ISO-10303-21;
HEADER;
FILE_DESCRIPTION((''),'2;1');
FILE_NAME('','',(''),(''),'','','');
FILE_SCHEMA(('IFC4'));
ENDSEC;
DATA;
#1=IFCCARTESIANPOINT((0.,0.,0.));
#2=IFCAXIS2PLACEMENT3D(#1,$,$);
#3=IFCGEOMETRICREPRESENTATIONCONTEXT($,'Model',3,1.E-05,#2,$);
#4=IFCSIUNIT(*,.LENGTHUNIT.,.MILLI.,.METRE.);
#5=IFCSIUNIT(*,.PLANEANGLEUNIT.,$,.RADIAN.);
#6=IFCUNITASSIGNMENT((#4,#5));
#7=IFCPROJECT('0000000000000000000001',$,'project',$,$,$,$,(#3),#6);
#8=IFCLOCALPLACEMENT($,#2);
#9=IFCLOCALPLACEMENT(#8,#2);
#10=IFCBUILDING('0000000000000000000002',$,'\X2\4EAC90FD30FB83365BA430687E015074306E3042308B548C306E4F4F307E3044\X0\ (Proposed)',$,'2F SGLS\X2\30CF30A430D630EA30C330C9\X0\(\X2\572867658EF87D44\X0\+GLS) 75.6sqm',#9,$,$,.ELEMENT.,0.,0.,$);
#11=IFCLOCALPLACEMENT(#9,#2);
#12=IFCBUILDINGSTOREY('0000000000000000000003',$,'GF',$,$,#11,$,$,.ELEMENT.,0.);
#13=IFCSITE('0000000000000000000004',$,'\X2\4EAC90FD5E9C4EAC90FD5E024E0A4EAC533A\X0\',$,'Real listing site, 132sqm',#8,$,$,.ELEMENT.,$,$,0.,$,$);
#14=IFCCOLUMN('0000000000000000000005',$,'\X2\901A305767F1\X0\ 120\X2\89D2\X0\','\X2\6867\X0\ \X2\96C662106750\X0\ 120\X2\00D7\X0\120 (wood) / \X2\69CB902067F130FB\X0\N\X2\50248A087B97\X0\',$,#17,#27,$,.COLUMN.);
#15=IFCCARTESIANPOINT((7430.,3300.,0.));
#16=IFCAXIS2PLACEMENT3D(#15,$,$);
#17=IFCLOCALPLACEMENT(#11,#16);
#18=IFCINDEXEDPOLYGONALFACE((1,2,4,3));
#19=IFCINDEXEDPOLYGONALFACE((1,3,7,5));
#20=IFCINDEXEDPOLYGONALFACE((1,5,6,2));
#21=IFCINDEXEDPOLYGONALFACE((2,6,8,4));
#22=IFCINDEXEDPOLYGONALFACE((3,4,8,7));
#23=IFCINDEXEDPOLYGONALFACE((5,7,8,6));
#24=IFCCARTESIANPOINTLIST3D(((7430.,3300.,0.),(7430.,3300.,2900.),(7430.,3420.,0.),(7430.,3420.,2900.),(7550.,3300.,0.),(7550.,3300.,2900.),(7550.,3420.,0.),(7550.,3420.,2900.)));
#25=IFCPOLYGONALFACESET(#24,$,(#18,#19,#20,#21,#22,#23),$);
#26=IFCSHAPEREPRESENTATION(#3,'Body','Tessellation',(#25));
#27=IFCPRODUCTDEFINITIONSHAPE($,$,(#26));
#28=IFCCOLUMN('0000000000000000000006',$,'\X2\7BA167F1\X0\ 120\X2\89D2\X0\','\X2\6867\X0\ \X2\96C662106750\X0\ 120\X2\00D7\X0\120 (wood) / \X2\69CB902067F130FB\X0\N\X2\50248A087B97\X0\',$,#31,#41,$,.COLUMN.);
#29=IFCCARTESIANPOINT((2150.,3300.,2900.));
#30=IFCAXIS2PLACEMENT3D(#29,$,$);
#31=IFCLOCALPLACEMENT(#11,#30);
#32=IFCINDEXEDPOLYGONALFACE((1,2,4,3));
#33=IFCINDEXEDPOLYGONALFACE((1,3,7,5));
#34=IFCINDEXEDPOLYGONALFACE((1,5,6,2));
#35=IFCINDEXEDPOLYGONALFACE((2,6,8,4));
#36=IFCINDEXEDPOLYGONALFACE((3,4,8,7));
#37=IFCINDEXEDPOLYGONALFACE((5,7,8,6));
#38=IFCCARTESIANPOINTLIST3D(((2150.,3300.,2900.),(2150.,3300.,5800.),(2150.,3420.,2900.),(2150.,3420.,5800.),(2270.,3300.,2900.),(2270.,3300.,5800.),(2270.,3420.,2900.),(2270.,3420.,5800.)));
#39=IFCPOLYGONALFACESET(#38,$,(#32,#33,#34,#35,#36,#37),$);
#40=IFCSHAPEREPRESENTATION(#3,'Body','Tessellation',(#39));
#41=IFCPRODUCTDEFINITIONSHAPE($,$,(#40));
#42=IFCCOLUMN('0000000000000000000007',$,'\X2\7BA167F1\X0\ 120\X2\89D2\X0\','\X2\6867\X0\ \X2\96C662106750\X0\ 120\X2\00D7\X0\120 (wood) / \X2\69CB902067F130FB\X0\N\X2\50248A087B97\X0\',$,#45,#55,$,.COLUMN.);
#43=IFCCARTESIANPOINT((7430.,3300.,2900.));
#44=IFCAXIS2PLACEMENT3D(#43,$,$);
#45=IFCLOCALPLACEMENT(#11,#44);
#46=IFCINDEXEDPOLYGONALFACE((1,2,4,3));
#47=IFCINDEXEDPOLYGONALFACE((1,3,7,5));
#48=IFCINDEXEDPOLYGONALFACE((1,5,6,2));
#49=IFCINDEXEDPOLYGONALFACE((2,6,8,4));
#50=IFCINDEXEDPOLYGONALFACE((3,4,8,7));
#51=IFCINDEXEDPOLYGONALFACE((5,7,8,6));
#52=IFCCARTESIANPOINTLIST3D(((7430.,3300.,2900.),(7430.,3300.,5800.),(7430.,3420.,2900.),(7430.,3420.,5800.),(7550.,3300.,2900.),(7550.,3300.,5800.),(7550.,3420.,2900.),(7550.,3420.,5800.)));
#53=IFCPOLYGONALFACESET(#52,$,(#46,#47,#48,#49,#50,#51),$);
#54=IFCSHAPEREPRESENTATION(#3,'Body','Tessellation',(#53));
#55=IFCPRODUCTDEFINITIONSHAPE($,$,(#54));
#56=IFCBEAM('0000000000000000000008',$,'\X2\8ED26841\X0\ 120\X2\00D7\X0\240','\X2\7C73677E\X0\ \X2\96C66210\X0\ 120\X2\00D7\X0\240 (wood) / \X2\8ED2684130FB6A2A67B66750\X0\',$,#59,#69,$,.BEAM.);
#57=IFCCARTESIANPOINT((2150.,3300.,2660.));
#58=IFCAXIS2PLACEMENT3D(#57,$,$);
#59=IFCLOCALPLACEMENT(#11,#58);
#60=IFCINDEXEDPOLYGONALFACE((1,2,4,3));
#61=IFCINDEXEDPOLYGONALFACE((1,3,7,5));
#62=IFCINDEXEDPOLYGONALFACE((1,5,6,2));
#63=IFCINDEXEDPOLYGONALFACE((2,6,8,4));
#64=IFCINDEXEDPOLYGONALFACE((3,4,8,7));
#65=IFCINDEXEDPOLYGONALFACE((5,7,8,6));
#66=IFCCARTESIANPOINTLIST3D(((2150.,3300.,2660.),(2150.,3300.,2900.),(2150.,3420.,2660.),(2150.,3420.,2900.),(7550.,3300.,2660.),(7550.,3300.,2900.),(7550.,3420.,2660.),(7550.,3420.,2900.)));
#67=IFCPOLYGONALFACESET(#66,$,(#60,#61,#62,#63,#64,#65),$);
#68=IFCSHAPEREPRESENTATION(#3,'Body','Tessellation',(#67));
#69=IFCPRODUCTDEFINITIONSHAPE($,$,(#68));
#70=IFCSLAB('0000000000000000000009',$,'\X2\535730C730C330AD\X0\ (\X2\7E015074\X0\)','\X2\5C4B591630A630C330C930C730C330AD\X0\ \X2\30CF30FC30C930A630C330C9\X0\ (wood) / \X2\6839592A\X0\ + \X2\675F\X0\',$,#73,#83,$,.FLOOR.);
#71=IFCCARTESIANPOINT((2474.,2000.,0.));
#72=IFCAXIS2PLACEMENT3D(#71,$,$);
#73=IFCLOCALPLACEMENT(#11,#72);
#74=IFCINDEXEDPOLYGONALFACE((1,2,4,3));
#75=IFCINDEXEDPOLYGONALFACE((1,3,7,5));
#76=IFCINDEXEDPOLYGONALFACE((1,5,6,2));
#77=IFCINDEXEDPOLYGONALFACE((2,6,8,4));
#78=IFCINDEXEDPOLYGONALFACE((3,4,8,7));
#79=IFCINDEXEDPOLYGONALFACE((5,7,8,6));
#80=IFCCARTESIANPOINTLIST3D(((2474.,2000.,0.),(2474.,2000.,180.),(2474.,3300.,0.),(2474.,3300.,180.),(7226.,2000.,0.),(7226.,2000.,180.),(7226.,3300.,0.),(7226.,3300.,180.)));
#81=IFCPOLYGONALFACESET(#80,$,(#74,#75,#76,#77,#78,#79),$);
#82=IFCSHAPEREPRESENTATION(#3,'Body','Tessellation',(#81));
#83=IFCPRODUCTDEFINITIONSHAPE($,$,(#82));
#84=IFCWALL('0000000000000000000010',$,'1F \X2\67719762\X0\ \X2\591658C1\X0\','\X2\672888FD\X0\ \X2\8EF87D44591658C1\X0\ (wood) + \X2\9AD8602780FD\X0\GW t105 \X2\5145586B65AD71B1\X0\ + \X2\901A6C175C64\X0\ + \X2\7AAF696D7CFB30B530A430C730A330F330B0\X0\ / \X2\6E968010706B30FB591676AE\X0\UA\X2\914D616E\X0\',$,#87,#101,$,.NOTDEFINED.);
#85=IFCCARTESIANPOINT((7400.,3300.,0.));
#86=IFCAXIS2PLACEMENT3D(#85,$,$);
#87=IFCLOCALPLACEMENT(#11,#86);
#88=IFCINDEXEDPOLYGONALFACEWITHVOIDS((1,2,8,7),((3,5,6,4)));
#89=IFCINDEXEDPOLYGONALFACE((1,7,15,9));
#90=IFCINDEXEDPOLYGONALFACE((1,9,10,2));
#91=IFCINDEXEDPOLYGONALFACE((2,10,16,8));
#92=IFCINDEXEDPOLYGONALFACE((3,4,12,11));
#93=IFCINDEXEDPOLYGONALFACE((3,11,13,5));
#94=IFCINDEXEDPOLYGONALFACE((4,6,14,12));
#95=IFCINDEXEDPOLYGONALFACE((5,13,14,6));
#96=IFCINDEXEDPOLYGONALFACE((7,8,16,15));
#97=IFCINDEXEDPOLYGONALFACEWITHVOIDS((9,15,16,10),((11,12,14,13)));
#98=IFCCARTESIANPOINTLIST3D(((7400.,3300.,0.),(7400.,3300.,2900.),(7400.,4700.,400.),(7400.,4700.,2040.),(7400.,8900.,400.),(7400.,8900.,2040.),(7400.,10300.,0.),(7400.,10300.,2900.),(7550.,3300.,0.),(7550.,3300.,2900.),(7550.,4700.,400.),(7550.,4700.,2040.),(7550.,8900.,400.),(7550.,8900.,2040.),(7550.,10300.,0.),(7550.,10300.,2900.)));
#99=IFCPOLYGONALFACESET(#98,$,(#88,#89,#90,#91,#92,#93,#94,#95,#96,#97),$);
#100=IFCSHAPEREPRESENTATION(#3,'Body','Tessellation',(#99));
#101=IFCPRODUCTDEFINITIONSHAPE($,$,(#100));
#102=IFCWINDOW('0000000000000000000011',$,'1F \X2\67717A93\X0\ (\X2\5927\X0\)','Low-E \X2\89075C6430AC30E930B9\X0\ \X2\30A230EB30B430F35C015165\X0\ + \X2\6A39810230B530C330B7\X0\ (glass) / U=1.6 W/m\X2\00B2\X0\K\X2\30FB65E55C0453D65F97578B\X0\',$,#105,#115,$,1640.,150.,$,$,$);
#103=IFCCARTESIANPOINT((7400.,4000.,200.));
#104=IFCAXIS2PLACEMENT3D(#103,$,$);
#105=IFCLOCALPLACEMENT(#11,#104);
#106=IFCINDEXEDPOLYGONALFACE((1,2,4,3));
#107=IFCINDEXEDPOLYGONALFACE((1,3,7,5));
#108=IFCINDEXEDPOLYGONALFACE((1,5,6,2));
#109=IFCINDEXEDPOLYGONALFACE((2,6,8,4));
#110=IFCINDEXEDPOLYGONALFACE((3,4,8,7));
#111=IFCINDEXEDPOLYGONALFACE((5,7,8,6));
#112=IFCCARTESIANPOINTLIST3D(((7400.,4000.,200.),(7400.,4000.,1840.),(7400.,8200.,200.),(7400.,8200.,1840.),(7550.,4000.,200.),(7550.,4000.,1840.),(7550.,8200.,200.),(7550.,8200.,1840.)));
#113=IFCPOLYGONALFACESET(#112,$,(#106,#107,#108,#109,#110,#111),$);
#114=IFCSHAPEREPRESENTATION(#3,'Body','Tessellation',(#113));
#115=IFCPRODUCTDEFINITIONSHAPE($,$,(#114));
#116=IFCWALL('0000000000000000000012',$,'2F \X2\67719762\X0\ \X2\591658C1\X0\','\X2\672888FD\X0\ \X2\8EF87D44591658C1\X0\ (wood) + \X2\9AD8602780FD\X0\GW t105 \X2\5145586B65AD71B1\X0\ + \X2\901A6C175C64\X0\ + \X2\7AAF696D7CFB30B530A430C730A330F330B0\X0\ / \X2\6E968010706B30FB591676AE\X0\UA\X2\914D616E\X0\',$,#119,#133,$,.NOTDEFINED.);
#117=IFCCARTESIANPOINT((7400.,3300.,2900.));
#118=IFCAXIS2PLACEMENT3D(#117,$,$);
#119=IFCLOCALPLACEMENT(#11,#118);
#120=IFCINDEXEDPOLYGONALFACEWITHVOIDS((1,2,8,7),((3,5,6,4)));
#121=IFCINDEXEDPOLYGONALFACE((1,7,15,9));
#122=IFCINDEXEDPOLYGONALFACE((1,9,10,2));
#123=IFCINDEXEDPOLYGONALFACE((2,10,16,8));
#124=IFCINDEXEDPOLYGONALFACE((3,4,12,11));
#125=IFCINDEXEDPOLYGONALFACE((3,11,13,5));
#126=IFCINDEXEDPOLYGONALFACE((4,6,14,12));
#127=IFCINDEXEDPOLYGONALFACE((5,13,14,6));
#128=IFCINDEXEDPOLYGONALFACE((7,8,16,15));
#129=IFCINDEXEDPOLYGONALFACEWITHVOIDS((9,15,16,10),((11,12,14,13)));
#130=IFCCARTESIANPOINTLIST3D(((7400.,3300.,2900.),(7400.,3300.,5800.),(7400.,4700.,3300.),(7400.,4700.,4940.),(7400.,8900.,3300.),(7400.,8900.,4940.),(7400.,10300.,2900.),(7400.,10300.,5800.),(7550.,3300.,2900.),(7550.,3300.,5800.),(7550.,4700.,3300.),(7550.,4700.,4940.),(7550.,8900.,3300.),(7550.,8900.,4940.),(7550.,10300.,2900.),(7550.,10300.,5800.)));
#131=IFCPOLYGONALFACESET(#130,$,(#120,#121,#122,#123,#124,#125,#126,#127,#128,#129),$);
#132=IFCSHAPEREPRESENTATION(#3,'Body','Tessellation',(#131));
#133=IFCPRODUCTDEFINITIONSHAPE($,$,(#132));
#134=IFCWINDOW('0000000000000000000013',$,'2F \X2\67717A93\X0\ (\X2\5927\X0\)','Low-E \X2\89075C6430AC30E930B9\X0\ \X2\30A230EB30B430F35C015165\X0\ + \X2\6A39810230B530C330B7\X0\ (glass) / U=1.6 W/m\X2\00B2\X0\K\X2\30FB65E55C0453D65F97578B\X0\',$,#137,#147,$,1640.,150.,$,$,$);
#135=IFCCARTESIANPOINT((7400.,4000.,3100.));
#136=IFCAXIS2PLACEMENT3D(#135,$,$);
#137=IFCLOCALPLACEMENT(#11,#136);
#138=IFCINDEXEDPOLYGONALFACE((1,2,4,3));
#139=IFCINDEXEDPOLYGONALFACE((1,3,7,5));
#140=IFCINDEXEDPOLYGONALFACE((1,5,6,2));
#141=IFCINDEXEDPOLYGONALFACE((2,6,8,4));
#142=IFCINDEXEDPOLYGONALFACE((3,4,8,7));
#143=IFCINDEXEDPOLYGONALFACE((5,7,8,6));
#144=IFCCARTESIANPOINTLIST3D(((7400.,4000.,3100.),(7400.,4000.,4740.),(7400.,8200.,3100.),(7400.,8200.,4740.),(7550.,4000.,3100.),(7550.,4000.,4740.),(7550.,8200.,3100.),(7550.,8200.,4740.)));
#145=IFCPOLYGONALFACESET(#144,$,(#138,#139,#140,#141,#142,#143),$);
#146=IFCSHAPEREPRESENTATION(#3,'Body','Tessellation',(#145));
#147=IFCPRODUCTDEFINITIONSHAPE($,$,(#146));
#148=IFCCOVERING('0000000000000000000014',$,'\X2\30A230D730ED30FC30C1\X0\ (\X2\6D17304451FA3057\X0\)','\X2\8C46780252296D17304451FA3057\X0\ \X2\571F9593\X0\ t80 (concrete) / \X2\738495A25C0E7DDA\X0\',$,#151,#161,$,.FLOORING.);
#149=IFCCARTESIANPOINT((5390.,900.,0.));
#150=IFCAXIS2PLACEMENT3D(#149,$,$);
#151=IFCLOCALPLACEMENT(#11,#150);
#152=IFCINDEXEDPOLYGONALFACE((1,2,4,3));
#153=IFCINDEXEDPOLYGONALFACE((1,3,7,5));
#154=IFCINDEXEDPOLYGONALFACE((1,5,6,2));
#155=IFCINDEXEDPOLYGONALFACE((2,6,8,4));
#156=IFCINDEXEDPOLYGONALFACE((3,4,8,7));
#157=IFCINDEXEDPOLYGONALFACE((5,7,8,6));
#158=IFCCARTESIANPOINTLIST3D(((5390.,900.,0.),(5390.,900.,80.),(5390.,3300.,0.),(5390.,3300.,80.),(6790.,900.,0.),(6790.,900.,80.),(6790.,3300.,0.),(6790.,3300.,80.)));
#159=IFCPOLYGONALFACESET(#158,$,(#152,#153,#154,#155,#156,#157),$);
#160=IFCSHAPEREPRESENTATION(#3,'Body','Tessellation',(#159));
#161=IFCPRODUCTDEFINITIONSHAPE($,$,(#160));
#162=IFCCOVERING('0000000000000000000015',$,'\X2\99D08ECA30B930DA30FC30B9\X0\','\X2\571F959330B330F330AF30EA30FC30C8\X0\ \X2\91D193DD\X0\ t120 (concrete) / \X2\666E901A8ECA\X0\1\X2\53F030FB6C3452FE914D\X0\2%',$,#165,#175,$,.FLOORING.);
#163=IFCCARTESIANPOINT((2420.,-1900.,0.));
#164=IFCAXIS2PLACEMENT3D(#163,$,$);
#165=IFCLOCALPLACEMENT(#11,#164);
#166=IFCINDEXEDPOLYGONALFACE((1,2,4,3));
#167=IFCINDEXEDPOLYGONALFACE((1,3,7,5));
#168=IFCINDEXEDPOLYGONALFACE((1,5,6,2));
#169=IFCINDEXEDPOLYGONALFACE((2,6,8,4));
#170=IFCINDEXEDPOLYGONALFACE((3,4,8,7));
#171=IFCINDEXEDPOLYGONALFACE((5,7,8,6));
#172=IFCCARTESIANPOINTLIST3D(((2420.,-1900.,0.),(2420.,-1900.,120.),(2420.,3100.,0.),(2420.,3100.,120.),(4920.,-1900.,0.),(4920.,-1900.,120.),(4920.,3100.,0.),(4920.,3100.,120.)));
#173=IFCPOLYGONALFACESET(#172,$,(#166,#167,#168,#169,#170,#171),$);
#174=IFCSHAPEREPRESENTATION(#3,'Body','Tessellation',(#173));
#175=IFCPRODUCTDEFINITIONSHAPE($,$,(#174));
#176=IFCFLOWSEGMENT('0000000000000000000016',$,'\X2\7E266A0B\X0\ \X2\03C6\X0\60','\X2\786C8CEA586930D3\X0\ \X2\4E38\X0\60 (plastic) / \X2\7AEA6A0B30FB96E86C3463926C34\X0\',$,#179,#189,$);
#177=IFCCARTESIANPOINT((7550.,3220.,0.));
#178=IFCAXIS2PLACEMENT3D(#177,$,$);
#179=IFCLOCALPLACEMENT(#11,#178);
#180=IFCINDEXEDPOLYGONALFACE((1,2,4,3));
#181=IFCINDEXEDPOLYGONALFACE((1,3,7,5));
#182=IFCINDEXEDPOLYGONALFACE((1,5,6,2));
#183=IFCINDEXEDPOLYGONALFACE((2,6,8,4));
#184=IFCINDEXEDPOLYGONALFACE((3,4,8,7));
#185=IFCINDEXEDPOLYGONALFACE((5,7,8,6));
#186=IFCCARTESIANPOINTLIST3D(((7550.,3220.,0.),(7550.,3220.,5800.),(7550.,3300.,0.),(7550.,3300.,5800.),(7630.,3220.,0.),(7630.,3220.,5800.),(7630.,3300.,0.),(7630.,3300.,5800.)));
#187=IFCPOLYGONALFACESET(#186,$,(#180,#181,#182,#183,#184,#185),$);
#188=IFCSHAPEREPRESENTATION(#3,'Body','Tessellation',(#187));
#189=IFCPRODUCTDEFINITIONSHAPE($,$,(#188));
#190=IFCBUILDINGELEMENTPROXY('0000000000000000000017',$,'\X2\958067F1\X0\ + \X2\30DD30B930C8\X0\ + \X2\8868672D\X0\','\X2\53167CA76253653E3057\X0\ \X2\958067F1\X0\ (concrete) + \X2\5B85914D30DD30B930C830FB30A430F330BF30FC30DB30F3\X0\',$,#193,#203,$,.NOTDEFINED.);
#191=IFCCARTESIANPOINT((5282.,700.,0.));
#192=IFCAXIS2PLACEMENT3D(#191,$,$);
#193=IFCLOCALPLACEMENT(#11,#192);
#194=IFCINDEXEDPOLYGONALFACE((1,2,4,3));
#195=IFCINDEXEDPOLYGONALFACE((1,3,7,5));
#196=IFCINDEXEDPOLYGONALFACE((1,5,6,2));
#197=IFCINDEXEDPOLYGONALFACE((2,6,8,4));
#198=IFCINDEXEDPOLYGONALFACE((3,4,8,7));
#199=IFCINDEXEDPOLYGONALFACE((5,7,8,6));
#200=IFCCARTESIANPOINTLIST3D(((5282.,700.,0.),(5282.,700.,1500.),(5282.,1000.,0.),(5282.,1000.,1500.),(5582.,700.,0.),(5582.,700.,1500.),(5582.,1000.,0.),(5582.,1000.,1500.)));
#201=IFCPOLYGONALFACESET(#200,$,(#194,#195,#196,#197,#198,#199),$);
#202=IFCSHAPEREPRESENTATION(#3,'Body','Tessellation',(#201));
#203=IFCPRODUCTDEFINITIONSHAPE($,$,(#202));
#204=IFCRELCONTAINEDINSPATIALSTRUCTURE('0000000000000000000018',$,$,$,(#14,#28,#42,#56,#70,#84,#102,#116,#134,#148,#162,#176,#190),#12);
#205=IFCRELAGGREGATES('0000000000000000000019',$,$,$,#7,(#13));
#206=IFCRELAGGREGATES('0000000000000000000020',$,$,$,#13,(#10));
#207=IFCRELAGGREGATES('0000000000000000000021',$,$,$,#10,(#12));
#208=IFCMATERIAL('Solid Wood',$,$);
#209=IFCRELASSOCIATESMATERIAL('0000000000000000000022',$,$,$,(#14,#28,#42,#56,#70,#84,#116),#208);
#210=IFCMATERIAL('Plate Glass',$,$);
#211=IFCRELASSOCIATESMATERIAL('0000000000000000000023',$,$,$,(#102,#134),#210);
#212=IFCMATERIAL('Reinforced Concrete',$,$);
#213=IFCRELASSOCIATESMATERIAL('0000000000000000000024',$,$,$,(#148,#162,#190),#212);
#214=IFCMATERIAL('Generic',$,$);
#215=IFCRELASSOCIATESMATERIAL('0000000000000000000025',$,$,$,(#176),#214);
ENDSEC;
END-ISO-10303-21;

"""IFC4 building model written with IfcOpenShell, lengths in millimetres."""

from ifc_helpers import new_model, si_unit, frame, frame_2d, origin, place, context, project, spatial, rectangle, extrude, material, element, fill, save


model = new_model("IFC4")

# Units and contexts
model_context = context("Model", 3, precision=1e-05, world=origin())
ifc_project = project(units=[si_unit("LENGTHUNIT", "METRE", prefix="MILLI"), si_unit("PLANEANGLEUNIT", "RADIAN")], contexts=[model_context])

# Site, building, storey
site_placement = place(None, origin())
site = spatial("IfcSite", under=ifc_project, at=site_placement, Name="京都府京都市上京区", ObjectType="Real listing site, 132sqm", CompositionType="ELEMENT", RefElevation=0.0)
building_placement = place(site_placement, origin())
building = spatial("IfcBuilding", under=site, at=building_placement, Name="京都・茶室と縁側のある和の住まい (Proposed)", ObjectType="2F SGLSハイブリッド(在来軸組+GLS) 75.6sqm", CompositionType="ELEMENT", ElevationOfRefHeight=0.0, ElevationOfTerrain=0.0)
storey_placement = place(building_placement, origin())
storey = spatial("IfcBuildingStorey", under=building, at=storey_placement, Name="GF", CompositionType="ELEMENT", Elevation=0.0)

# Columns
ifc_material_1 = material(Name="Solid Wood")
column_1_placement = place(storey_placement, frame((7430.0, 3300.0, 0.0)))
element("IfcColumn", 1, at=column_1_placement, inside=storey, material=ifc_material_1, Name="通し柱 120角", Description="桧 集成材 120×120 (wood) / 構造柱・N値計算", PredefinedType="COLUMN", context=model_context, shape_type="SweptSolid", body=[
    extrude(rectangle(XDim=120.0, YDim=120.0, at=frame_2d((60.0, 60.0))), frame((7430.0, 3300.0, 0.0)), (0.0, 0.0, 1.0), 2900.0),
])
column_2_placement = place(storey_placement, frame((2150.0, 3300.0, 2900.0)))
element("IfcColumn", 2, at=column_2_placement, inside=storey, material=ifc_material_1, Name="管柱 120角", Description="桧 集成材 120×120 (wood) / 構造柱・N値計算", PredefinedType="COLUMN", context=model_context, shape_type="SweptSolid", body=[
    extrude(rectangle(XDim=120.0, YDim=120.0, at=frame_2d((60.0, 60.0))), frame((2150.0, 3300.0, 2900.0)), (0.0, 0.0, 1.0), 2900.0),
])
column_3_placement = place(storey_placement, frame((7430.0, 3300.0, 2900.0)))
element("IfcColumn", 3, at=column_3_placement, inside=storey, material=ifc_material_1, Name="管柱 120角", Description="桧 集成材 120×120 (wood) / 構造柱・N値計算", PredefinedType="COLUMN", context=model_context, shape_type="SweptSolid", body=[
    extrude(rectangle(XDim=120.0, YDim=120.0, at=frame_2d((60.0, 60.0))), frame((7430.0, 3300.0, 2900.0)), (0.0, 0.0, 1.0), 2900.0),
])

# Beam
beam_1_placement = place(storey_placement, frame((2150.0, 3300.0, 2660.0)))
element("IfcBeam", 4, at=beam_1_placement, inside=storey, material=ifc_material_1, Name="軒桁 120×240", Description="米松 集成 120×240 (wood) / 軒桁・横架材", PredefinedType="BEAM", context=model_context, shape_type="SweptSolid", body=[
    extrude(rectangle(XDim=5400.0, YDim=120.0, at=frame_2d((2700.0, 60.0))), frame((2150.0, 3300.0, 2660.0)), (0.0, 0.0, 1.0), 240.0),
])

# Slab
slab_placement = place(storey_placement, frame((2474.0, 2000.0, 0.0)))
element("IfcSlab", 5, at=slab_placement, inside=storey, material=ifc_material_1, Name="南デッキ (縁側)", Description="屋外ウッドデッキ ハードウッド (wood) / 根太 + 束", PredefinedType="FLOOR", context=model_context, shape_type="SweptSolid", body=[
    extrude(rectangle(XDim=4752.0, YDim=1300.0, at=frame_2d((2376.0, 650.0))), frame((2474.0, 2000.0, 0.0)), (0.0, 0.0, 1.0), 180.0),
])

# Walls, openings, windows
wall_1_placement = place(storey_placement, frame((7400.0, 3300.0, 0.0)))
wall_1 = element("IfcWall", 6, at=wall_1_placement, inside=storey, material=ifc_material_1, Name="1F 東面 外壁", Description="木製 軸組外壁 (wood) + 高性能GW t105 充填断熱 + 通気層 + 窯業系サイディング / 準耐火・外皮UA配慮", PredefinedType="NOTDEFINED", context=model_context, shape_type="SweptSolid", body=[
    extrude(rectangle(XDim=150.0, YDim=7000.0, at=frame_2d((75.0, 3500.0))), frame((7400.0, 3300.0, 0.0)), (0.0, 0.0, 1.0), 2900.0),
])
opening_1_placement = place(storey_placement, frame((7400.0, 4000.0, 200.0)))
opening_1 = element("IfcOpeningElement", 7, at=opening_1_placement, cuts=wall_1, PredefinedType="NOTDEFINED", context=model_context, shape_type="SweptSolid", body=[
    extrude(rectangle(XDim=150.0, YDim=4200.0, at=frame_2d((75.0, 2100.0))), frame((7400.0, 4000.0, 200.0)), (0.0, 0.0, 1.0), 1640.0),
])
ifc_material_2 = material(Name="Plate Glass")
window_1_placement = place(storey_placement, frame((7400.0, 4000.0, 200.0)))
window_1 = element("IfcWindow", 8, at=window_1_placement, inside=storey, material=ifc_material_2, Name="1F 東窓 (大)", Description="Low-E 複層ガラス アルゴン封入 + 樹脂サッシ (glass) / U=1.6 W/m²K・日射取得型", OverallHeight=1640.0, OverallWidth=150.0, context=model_context, shape_type="SweptSolid", body=[
    extrude(rectangle(XDim=150.0, YDim=4200.0, at=frame_2d((75.0, 2100.0))), frame((7400.0, 4000.0, 200.0)), (0.0, 0.0, 1.0), 1640.0),
])
fill(opening_1, window_1)
wall_2_placement = place(storey_placement, frame((7400.0, 3300.0, 2900.0)))
wall_2 = element("IfcWall", 9, at=wall_2_placement, inside=storey, material=ifc_material_1, Name="2F 東面 外壁", Description="木製 軸組外壁 (wood) + 高性能GW t105 充填断熱 + 通気層 + 窯業系サイディング / 準耐火・外皮UA配慮", PredefinedType="NOTDEFINED", context=model_context, shape_type="SweptSolid", body=[
    extrude(rectangle(XDim=150.0, YDim=7000.0, at=frame_2d((75.0, 3500.0))), frame((7400.0, 3300.0, 2900.0)), (0.0, 0.0, 1.0), 2900.0),
])
opening_2_placement = place(storey_placement, frame((7400.0, 4000.0, 3100.0)))
opening_2 = element("IfcOpeningElement", 10, at=opening_2_placement, cuts=wall_2, PredefinedType="NOTDEFINED", context=model_context, shape_type="SweptSolid", body=[
    extrude(rectangle(XDim=150.0, YDim=4200.0, at=frame_2d((75.0, 2100.0))), frame((7400.0, 4000.0, 3100.0)), (0.0, 0.0, 1.0), 1640.0),
])
window_2_placement = place(storey_placement, frame((7400.0, 4000.0, 3100.0)))
window_2 = element("IfcWindow", 11, at=window_2_placement, inside=storey, material=ifc_material_2, Name="2F 東窓 (大)", Description="Low-E 複層ガラス アルゴン封入 + 樹脂サッシ (glass) / U=1.6 W/m²K・日射取得型", OverallHeight=1640.0, OverallWidth=150.0, context=model_context, shape_type="SweptSolid", body=[
    extrude(rectangle(XDim=150.0, YDim=4200.0, at=frame_2d((75.0, 2100.0))), frame((7400.0, 4000.0, 3100.0)), (0.0, 0.0, 1.0), 1640.0),
])
fill(opening_2, window_2)

# Coverings
ifc_material_3 = material(Name="Reinforced Concrete")
covering_1_placement = place(storey_placement, frame((5390.0, 900.0, 0.0)))
element("IfcCovering", 12, at=covering_1_placement, inside=storey, material=ifc_material_3, Name="アプローチ (洗い出し)", Description="豆砂利洗い出し 土間 t80 (concrete) / 玄関導線", PredefinedType="FLOORING", context=model_context, shape_type="SweptSolid", body=[
    extrude(rectangle(XDim=1400.0, YDim=2400.0, at=frame_2d((700.0, 1200.0))), frame((5390.0, 900.0, 0.0)), (0.0, 0.0, 1.0), 80.0),
])
covering_2_placement = place(storey_placement, frame((2420.0, -1900.0, 0.0)))
element("IfcCovering", 13, at=covering_2_placement, inside=storey, material=ifc_material_3, Name="駐車スペース", Description="土間コンクリート 金鏝 t120 (concrete) / 普通車1台・水勾配2%", PredefinedType="FLOORING", context=model_context, shape_type="SweptSolid", body=[
    extrude(rectangle(XDim=2500.0, YDim=5000.0, at=frame_2d((1250.0, 2500.0))), frame((2420.0, -1900.0, 0.0)), (0.0, 0.0, 1.0), 120.0),
])

# Flow segment
ifc_material_4 = material(Name="Generic")
flow_segment_placement = place(storey_placement, frame((7550.0, 3220.0, 0.0)))
element("IfcFlowSegment", 14, at=flow_segment_placement, inside=storey, material=ifc_material_4, Name="縦樋 φ60", Description="硬質塩ビ 丸60 (plastic) / 竪樋・雨水排水", context=model_context, shape_type="SweptSolid", body=[
    extrude(rectangle(XDim=80.0, YDim=80.0, at=frame_2d((40.0, 40.0))), frame((7550.0, 3220.0, 0.0)), (0.0, 0.0, 1.0), 5800.0),
])

# Building element proxy
proxy_placement = place(storey_placement, frame((5282.0, 700.0, 0.0)))
element("IfcBuildingElementProxy", 15, at=proxy_placement, inside=storey, material=ifc_material_3, Name="門柱 + ポスト + 表札", Description="化粧打放し 門柱 (concrete) + 宅配ポスト・インターホン", PredefinedType="NOTDEFINED", context=model_context, shape_type="SweptSolid", body=[
    extrude(rectangle(XDim=300.0, YDim=300.0, at=frame_2d((150.0, 150.0))), frame((5282.0, 700.0, 0.0)), (0.0, 0.0, 1.0), 1500.0),
])

save(model, "model.ifc")
